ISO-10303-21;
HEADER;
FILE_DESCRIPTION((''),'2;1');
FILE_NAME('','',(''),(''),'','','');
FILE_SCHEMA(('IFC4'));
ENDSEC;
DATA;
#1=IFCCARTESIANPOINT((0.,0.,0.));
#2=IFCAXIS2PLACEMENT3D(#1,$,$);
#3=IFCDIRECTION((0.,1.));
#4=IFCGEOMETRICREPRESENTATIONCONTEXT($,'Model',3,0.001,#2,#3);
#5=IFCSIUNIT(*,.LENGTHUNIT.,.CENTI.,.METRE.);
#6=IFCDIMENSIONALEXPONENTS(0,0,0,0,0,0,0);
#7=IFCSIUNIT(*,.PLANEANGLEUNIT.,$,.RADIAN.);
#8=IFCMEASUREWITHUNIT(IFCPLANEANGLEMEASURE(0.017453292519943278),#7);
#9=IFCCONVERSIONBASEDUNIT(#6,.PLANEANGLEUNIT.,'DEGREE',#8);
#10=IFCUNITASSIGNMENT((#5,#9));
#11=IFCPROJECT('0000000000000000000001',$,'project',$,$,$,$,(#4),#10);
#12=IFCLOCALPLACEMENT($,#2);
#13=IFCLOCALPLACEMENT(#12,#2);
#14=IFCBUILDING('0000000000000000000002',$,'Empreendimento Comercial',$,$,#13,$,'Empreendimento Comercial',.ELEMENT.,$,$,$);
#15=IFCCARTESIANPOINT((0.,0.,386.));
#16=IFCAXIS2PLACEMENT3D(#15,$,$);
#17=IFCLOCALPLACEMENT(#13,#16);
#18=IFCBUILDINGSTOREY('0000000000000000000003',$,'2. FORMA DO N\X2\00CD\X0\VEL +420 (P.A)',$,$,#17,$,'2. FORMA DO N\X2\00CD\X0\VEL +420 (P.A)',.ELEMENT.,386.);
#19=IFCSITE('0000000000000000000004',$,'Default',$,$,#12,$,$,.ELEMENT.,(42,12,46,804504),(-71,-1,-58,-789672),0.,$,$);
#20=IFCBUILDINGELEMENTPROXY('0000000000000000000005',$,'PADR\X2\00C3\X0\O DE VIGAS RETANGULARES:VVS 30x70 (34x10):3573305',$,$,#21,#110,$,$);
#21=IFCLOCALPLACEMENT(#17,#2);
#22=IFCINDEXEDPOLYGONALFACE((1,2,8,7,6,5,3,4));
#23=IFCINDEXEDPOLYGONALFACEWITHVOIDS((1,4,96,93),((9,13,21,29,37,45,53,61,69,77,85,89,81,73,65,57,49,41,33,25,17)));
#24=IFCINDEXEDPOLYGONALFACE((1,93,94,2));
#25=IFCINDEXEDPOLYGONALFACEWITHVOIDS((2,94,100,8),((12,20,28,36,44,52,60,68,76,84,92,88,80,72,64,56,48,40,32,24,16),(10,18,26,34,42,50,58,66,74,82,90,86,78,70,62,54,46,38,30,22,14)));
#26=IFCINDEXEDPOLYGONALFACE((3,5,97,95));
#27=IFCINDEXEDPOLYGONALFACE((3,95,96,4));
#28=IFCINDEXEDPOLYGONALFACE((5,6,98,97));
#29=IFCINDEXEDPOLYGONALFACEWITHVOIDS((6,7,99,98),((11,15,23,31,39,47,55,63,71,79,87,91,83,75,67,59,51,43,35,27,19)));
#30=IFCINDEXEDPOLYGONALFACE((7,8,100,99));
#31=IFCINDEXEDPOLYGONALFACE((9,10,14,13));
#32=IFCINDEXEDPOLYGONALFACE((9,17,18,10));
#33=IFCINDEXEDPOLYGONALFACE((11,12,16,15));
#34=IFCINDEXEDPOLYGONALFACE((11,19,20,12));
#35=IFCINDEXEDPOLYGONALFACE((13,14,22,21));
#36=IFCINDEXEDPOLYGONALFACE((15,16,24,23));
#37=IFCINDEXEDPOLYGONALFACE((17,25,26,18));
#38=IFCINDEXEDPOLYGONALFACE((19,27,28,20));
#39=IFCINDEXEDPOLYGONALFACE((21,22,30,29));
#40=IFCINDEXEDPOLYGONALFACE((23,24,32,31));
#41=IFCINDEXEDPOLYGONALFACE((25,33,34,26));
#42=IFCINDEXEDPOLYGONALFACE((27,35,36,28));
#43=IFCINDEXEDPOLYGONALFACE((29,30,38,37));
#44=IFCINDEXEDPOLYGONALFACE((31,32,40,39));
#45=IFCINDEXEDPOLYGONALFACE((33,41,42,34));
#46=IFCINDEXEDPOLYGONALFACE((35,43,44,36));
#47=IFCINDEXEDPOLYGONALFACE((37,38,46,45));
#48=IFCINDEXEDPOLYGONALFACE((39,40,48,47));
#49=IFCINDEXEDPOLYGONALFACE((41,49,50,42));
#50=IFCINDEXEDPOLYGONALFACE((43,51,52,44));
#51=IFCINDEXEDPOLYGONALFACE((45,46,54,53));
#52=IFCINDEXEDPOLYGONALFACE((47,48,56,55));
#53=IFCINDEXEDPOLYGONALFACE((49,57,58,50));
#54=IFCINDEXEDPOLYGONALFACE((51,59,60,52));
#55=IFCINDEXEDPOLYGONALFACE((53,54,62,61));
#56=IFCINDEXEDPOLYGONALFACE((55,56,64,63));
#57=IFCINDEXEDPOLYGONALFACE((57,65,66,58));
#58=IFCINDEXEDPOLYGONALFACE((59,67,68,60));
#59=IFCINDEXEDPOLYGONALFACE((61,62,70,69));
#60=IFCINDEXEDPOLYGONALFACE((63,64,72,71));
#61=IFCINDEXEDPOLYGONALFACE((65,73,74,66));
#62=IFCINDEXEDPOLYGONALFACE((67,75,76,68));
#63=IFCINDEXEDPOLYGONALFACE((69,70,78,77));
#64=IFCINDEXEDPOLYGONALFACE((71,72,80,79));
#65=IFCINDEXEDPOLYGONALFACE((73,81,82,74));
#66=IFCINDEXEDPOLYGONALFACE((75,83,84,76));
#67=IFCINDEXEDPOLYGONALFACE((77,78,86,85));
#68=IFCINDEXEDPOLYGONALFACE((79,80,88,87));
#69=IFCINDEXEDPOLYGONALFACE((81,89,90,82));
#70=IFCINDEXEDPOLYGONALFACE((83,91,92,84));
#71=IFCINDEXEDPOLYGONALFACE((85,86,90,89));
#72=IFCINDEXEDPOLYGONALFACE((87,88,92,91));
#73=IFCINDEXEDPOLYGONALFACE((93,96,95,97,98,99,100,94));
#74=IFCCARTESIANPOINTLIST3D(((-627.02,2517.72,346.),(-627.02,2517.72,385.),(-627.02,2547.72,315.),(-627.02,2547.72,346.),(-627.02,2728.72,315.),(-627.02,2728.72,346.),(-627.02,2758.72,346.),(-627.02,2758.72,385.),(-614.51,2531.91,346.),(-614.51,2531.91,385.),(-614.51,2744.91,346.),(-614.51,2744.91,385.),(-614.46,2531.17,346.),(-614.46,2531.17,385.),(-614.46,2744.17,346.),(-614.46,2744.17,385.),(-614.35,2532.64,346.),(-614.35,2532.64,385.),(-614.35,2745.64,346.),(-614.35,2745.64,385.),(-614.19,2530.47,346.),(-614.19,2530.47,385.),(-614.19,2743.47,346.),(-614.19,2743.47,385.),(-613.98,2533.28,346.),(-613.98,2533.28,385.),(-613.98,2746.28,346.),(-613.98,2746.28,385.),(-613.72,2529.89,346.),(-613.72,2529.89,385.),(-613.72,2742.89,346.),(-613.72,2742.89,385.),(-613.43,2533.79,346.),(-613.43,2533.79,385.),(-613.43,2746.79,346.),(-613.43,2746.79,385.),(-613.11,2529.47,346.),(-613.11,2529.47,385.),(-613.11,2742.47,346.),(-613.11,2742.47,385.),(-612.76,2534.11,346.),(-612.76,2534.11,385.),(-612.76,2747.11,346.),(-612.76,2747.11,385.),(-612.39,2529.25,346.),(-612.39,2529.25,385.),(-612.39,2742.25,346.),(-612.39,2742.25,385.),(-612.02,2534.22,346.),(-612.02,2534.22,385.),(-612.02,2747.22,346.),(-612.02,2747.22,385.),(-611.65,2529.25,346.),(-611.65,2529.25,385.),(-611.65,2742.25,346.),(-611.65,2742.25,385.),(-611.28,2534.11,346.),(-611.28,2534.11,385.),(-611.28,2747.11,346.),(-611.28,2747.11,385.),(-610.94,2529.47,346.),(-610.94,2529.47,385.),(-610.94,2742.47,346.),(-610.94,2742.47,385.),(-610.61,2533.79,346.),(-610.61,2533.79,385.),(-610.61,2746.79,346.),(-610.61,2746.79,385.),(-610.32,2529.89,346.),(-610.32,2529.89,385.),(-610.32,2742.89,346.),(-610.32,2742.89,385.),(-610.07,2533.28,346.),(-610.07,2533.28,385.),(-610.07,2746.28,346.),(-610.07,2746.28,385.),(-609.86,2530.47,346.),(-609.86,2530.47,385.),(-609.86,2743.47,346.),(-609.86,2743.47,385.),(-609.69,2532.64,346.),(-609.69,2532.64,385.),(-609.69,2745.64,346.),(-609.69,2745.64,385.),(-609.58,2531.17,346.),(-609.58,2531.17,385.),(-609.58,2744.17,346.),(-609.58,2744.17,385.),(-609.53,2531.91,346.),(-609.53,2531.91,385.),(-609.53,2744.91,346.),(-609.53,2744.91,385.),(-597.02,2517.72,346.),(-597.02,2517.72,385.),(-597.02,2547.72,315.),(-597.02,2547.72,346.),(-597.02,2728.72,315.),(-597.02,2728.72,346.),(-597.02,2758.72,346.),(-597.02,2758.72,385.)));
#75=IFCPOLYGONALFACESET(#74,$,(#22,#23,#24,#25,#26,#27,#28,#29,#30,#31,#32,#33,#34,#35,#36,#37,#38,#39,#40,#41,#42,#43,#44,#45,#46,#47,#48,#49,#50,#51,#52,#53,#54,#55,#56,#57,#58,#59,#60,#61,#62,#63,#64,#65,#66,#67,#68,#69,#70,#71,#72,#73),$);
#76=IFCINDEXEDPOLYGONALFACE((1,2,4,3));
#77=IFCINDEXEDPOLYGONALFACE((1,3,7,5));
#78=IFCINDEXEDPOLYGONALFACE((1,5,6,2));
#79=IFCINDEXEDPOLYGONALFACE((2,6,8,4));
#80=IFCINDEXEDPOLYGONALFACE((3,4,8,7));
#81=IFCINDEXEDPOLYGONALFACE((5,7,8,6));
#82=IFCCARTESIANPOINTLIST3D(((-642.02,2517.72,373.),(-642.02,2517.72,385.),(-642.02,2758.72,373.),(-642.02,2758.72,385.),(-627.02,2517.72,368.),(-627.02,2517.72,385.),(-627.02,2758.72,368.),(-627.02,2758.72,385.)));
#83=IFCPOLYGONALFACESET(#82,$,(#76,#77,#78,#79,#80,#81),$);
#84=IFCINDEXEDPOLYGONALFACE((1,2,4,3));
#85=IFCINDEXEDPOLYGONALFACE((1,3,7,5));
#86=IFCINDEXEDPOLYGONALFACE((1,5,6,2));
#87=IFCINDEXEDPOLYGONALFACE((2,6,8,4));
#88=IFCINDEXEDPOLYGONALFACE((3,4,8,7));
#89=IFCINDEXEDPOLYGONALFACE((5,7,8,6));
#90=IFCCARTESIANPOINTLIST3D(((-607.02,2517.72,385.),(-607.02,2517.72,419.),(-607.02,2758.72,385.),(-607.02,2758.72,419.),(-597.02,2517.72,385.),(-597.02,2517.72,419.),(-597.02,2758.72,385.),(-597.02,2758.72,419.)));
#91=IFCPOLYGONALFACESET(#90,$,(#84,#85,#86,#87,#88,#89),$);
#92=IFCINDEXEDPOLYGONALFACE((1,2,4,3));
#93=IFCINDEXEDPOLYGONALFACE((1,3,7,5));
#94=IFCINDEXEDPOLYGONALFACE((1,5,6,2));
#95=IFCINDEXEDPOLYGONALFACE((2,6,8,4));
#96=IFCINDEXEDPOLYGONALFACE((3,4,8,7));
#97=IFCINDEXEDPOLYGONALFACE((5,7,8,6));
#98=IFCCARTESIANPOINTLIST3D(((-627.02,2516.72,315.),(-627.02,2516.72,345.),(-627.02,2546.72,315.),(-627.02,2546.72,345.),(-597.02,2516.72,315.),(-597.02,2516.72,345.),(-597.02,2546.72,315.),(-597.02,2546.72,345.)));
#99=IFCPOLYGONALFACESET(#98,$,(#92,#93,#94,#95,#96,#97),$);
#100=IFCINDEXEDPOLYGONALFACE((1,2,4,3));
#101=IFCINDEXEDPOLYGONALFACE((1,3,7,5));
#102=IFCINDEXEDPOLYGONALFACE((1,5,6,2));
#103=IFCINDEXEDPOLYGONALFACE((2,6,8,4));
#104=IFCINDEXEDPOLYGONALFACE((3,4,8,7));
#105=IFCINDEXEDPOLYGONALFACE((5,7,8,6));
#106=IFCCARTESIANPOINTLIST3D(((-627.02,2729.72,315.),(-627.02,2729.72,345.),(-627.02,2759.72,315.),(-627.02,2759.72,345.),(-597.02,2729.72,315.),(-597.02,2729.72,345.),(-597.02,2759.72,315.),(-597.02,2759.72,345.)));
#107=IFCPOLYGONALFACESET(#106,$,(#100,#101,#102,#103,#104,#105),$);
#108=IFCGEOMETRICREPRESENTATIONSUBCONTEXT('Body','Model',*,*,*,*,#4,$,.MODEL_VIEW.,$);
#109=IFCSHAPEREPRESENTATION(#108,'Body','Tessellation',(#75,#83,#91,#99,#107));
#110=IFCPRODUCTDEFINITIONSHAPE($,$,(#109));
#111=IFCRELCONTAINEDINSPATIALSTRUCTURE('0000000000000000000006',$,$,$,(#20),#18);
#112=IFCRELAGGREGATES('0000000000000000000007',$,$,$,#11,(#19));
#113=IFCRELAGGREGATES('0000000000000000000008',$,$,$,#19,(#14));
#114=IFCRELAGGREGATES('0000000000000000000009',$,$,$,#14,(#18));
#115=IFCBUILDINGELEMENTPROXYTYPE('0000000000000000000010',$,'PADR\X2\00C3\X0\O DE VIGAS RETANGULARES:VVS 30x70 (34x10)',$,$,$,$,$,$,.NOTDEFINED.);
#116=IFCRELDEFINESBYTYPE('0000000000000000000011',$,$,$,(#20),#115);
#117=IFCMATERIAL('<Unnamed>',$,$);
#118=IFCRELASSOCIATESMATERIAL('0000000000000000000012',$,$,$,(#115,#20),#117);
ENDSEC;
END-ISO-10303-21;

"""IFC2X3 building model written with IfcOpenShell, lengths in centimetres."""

from ifc_helpers import new_model, entity, si_unit, converted_unit, direction, frame, frame_2d, origin, origin_2d_with_axis, place, context, subcontext, project, spatial, polyline, rectangle, circle, outline, extrude, source, transform, mapped, material, type_object, type_shapes, element, save


model = new_model("IFC2X3")

# Units and contexts
model_context = context("Model", 3, precision=0.001, world=origin(), true_north=direction((0.0, 1.0)))
body_context = subcontext(model_context, "Body", "Model", "MODEL_VIEW")
ifc_project = project(units=[si_unit("LENGTHUNIT", "METRE", prefix="CENTI"), converted_unit("PLANEANGLEUNIT", "DEGREE", entity("IfcPlaneAngleMeasure", 0.017453292519943278), si_unit("PLANEANGLEUNIT", "RADIAN"), dimensions=[0, 0, 0, 0, 0, 0, 0])], contexts=[model_context])

# Site, building, storey
site_placement = place(None, origin())
site = spatial("IfcSite", under=ifc_project, at=site_placement, Name="Default", CompositionType="ELEMENT", RefLatitude=(42, 12, 46, 804504), RefLongitude=(-71, -1, -58, -789672), RefElevation=0.0)
building_placement = place(site_placement, origin())
building = spatial("IfcBuilding", under=site, at=building_placement, Name="Empreendimento Comercial", LongName="Empreendimento Comercial", CompositionType="ELEMENT")
storey_placement = place(building_placement, frame((0.0, 0.0, 386.0)))
storey = spatial("IfcBuildingStorey", under=building, at=storey_placement, Name="2. FORMA DO NÍVEL +420 (P.A)", LongName="2. FORMA DO NÍVEL +420 (P.A)", CompositionType="ELEMENT", Elevation=386.0)

# Shared definitions
ifc_material_1 = material(Name="<Unnamed>")

# Building element proxy, openings
building_element_proxy_type_1 = type_object("IfcBuildingElementProxyType", Name="PADRÃO DE VIGAS RETANGULARES:VVS 30x70 (34x10)", PredefinedType="NOTDEFINED", material=ifc_material_1)
shared_shape_1 = source(origin(), body_context, "Body", "SweptSolid", [
    extrude(outline(polyline([(-120.5, -37.0), (120.5, -37.0), (120.5, 2.0), (90.5, 2.0), (90.5, 33.0), (-90.5, 33.0), (-90.5, 2.0), (-120.5, 2.0), (-120.5, -37.0)])), frame((-627.02, 2638.22, 734.0), z_axis=(1.0, 0.0, 0.0), x_axis=(0.0, -1.0, 0.0)), (0.0, 0.0, 1.0), 30.0),
    extrude(outline(polyline([(-7.5, -7.25), (7.5, -7.25), (7.5, 9.75), (-7.5, 4.75), (-7.5, -7.25)])), frame((-634.52, 2517.72, 763.75), z_axis=(0.0, 1.0, 0.0), x_axis=(1.0, 0.0, 0.0)), (0.0, 0.0, 1.0), 241.0),
    extrude(rectangle(XDim=10.0, YDim=241.0, at=frame_2d((0.0, 0.0), x_axis=(1.0, 0.0))), frame((-602.02, 2638.22, 771.0), z_axis=(0.0, 0.0, 1.0), x_axis=(-1.0, 0.0, 0.0)), (0.0, 0.0, 1.0), 34.0),
    extrude(rectangle(XDim=30.0, YDim=30.0, at=frame_2d((0.0, 0.0), x_axis=(1.0, 0.0))), frame((-612.02, 2531.72, 701.0), z_axis=(0.0, 0.0, 1.0), x_axis=(0.0, -1.0, 0.0)), (0.0, 0.0, 1.0), 30.0),
    extrude(rectangle(XDim=30.0, YDim=30.0, at=frame_2d((0.0, 0.0), x_axis=(1.0, 0.0))), frame((-612.02, 2744.72, 701.0), z_axis=(0.0, 0.0, 1.0), x_axis=(0.0, -1.0, 0.0)), (0.0, 0.0, 1.0), 30.0),
])
type_shapes(building_element_proxy_type_1, [shared_shape_1])
proxy_1_placement = place(storey_placement, frame((0.0, 0.0, -386.0)))
proxy_1 = element("IfcBuildingElementProxy", 1, at=proxy_1_placement, inside=storey, type_object=building_element_proxy_type_1, material=ifc_material_1, Name="PADRÃO DE VIGAS RETANGULARES:VVS 30x70 (34x10):3573305", context=body_context, shape_type="MappedRepresentation", body=[
    mapped(shared_shape_1, transform((0.0, 0.0, 0.0), scale=1.0)),
])
opening_1_placement = place(storey_placement, frame((0.0, 0.0, -386.0)))
element("IfcOpeningElement", 2, at=opening_1_placement, cuts=proxy_1, ObjectType="Opening", context=body_context, shape_type="SweptSolid", body=[
    extrude(circle(Radius=2.5, at=origin_2d_with_axis()), frame((-612.02, 2744.72, 732.0), z_axis=(0.0, 0.0, 1.0), x_axis=(0.0, 1.0, 0.0)), (0.0, 0.0, 1.0), 39.0),
])
opening_2_placement = place(storey_placement, frame((0.0, 0.0, -386.0)))
element("IfcOpeningElement", 3, at=opening_2_placement, cuts=proxy_1, ObjectType="Opening", context=body_context, shape_type="SweptSolid", body=[
    extrude(circle(Radius=2.5, at=origin_2d_with_axis()), frame((-612.02, 2531.72, 732.0), z_axis=(0.0, 0.0, 1.0), x_axis=(0.0, 1.0, 0.0)), (0.0, 0.0, 1.0), 39.0),
])

save(model, "model.ifc")
